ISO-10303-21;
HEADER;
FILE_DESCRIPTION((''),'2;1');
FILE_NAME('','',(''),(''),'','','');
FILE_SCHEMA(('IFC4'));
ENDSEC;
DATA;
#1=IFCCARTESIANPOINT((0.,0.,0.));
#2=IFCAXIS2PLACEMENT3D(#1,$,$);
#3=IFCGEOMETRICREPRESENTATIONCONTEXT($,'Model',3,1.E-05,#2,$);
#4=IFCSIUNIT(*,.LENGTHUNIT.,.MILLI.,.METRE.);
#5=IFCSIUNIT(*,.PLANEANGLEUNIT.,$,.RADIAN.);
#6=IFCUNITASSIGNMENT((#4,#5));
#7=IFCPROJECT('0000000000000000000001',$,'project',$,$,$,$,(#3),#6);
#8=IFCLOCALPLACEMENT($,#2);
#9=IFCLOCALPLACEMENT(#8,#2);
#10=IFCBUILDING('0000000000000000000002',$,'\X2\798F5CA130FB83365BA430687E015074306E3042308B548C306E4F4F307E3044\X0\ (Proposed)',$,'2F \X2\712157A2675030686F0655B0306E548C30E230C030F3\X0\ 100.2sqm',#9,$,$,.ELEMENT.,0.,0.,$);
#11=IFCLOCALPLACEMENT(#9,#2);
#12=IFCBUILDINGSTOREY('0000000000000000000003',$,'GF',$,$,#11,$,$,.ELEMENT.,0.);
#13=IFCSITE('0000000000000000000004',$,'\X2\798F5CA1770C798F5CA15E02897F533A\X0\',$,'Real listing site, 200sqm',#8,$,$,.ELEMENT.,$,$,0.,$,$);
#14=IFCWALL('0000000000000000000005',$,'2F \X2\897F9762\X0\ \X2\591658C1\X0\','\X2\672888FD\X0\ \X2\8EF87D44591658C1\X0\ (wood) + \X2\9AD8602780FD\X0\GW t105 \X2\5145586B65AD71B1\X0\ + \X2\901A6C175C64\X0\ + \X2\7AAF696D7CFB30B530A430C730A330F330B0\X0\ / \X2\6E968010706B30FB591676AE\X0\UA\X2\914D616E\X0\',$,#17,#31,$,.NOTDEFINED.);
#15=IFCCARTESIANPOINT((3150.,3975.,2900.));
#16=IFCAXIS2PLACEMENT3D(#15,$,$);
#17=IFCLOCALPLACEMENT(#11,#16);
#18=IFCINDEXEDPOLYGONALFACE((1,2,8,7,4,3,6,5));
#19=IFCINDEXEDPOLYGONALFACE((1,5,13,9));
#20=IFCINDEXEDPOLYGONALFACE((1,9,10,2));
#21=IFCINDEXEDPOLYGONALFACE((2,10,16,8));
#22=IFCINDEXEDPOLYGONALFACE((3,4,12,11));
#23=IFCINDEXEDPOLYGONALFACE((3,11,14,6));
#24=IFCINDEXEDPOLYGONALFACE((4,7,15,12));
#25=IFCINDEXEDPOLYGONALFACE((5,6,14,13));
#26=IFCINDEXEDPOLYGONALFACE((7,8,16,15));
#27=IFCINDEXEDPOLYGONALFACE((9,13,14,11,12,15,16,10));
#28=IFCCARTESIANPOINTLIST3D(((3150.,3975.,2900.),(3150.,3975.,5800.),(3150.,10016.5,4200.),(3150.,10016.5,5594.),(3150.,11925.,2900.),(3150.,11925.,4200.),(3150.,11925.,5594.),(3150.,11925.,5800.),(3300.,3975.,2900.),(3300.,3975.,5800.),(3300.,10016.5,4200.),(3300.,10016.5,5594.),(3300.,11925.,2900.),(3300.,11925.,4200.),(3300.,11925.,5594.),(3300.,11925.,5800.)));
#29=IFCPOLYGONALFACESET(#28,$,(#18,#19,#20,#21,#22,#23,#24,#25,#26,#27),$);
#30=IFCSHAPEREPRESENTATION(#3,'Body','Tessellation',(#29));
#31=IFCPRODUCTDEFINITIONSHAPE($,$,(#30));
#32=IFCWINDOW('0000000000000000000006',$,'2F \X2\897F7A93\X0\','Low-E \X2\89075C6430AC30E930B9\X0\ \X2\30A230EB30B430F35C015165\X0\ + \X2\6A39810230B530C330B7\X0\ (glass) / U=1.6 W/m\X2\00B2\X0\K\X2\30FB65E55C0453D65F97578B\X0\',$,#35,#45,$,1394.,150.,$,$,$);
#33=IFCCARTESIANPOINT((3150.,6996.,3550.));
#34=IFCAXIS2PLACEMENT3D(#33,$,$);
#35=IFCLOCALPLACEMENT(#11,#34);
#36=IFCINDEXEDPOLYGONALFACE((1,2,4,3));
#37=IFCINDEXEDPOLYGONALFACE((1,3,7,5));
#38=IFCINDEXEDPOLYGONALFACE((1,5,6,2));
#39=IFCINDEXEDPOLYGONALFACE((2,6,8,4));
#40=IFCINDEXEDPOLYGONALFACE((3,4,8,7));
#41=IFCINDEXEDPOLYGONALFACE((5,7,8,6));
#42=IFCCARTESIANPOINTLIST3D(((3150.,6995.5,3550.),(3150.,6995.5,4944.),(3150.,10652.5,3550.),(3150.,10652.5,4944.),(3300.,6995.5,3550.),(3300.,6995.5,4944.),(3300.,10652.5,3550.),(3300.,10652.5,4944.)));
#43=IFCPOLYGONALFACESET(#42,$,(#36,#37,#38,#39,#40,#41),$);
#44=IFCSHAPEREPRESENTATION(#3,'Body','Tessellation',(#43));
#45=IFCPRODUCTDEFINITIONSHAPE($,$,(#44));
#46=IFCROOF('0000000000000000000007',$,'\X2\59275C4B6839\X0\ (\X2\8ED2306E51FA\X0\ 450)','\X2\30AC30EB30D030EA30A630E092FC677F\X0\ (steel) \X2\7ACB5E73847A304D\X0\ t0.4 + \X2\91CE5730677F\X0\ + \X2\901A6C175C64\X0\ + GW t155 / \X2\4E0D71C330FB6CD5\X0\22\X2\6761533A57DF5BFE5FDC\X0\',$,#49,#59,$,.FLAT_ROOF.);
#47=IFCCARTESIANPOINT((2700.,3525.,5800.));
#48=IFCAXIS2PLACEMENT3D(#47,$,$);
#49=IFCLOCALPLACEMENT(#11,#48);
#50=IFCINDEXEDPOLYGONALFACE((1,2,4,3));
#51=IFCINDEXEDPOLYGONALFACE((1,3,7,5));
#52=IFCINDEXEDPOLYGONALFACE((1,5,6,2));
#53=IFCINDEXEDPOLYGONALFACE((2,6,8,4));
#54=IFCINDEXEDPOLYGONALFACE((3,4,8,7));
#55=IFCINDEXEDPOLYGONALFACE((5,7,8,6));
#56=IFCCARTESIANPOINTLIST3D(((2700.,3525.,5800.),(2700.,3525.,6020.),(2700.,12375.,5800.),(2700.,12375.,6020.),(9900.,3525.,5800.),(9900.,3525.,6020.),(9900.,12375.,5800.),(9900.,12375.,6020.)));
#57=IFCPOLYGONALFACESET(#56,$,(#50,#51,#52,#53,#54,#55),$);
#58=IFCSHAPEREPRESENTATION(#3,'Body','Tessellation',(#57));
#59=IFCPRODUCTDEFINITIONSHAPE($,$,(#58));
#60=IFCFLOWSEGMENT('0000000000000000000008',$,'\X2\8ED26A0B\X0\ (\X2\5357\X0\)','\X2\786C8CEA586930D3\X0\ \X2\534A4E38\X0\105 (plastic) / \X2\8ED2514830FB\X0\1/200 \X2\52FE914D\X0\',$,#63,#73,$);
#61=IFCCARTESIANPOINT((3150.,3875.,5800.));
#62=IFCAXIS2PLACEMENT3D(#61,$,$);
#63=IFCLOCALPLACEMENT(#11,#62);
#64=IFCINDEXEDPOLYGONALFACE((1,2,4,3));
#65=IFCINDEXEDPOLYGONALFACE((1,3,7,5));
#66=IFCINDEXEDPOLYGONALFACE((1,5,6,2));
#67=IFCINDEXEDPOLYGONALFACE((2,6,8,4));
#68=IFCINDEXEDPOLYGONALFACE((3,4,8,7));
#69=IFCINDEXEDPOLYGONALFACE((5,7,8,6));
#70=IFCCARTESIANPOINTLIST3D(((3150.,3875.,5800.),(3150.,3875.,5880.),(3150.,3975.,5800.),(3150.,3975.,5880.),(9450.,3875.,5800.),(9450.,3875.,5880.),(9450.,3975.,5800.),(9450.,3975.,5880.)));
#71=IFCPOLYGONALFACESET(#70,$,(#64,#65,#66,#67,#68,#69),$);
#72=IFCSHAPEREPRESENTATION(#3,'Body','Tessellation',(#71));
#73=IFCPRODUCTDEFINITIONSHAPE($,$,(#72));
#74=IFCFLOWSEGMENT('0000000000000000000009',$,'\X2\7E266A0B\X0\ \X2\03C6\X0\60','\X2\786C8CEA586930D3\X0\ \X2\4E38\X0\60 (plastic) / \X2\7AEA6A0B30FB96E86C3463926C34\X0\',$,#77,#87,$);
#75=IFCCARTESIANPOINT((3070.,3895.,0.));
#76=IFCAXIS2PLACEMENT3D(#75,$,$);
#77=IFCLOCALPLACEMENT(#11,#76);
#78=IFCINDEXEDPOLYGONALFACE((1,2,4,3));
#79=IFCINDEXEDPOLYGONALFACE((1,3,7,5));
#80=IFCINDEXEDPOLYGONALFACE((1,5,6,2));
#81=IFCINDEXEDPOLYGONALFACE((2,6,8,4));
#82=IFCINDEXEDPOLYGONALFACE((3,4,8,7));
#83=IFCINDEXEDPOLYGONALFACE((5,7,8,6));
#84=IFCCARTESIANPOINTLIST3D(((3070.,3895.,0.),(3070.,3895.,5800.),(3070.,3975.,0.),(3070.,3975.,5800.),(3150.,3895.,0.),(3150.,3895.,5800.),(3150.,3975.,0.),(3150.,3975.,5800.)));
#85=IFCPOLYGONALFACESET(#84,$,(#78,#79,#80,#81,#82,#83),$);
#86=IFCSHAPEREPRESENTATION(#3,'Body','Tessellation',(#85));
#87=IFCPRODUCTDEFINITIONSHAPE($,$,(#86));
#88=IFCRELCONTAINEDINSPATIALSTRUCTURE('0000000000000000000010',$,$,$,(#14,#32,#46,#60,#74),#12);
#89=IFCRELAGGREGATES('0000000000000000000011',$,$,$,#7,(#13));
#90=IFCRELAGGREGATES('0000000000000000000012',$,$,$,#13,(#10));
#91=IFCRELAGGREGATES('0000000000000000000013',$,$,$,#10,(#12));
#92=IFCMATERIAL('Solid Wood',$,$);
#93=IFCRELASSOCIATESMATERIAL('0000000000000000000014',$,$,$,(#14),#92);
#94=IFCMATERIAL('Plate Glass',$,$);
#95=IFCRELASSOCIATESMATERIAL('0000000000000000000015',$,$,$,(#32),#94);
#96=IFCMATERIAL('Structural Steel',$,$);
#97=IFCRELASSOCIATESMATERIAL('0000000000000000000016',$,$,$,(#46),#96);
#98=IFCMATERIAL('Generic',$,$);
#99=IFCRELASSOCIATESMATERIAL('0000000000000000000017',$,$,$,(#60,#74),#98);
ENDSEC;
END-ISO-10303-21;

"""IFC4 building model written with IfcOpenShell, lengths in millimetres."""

from ifc_helpers import new_model, si_unit, frame, frame_2d, origin, place, context, project, spatial, rectangle, extrude, material, element, fill, save


model = new_model("IFC4")

# Units and contexts
model_context = context("Model", 3, precision=1e-05, world=origin())
ifc_project = project(units=[si_unit("LENGTHUNIT", "METRE", prefix="MILLI"), si_unit("PLANEANGLEUNIT", "RADIAN")], contexts=[model_context])

# Site, building, storey
site_placement = place(None, origin())
site = spatial("IfcSite", under=ifc_project, at=site_placement, Name="福岡県福岡市西区", ObjectType="Real listing site, 200sqm", CompositionType="ELEMENT", RefElevation=0.0)
building_placement = place(site_placement, origin())
building = spatial("IfcBuilding", under=site, at=building_placement, Name="福岡・茶室と縁側のある和の住まい (Proposed)", ObjectType="2F 無垢材と漆喰の和モダン 100.2sqm", CompositionType="ELEMENT", ElevationOfRefHeight=0.0, ElevationOfTerrain=0.0)
storey_placement = place(building_placement, origin())
storey = spatial("IfcBuildingStorey", under=building, at=storey_placement, Name="GF", CompositionType="ELEMENT", Elevation=0.0)

# Shared definitions
ifc_material_1 = material(Name="Solid Wood")

# Shared definitions
ifc_material_2 = material(Name="Plate Glass")

# Wall, opening, window
wall_1_placement = place(storey_placement, frame((3150.0, 3975.0, 2900.0)))
wall_1 = element("IfcWall", 1, at=wall_1_placement, inside=storey, material=ifc_material_1, Name="2F 西面 外壁", Description="木製 軸組外壁 (wood) + 高性能GW t105 充填断熱 + 通気層 + 窯業系サイディング / 準耐火・外皮UA配慮", PredefinedType="NOTDEFINED", context=model_context, shape_type="SweptSolid", body=[
    extrude(rectangle(XDim=150.0, YDim=7950.0, at=frame_2d((75.0, 3975.0))), frame((3150.0, 3975.0, 2900.0)), (0.0, 0.0, 1.0), 2900.0),
])
opening_1_placement = place(storey_placement, frame((3150.0, 6996.0, 3550.0)))
opening_1 = element("IfcOpeningElement", 2, at=opening_1_placement, cuts=wall_1, PredefinedType="NOTDEFINED", context=model_context, shape_type="SweptSolid", body=[
    extrude(rectangle(XDim=150.0, YDim=3657.0, at=frame_2d((75.0, 1828.0))), frame((3150.0, 6996.0, 3550.0)), (0.0, 0.0, 1.0), 1394.0),
])
window_1_placement = place(storey_placement, frame((3150.0, 6996.0, 3550.0)))
window_1 = element("IfcWindow", 3, at=window_1_placement, inside=storey, material=ifc_material_2, Name="2F 西窓", Description="Low-E 複層ガラス アルゴン封入 + 樹脂サッシ (glass) / U=1.6 W/m²K・日射取得型", OverallHeight=1394.0, OverallWidth=150.0, context=model_context, shape_type="SweptSolid", body=[
    extrude(rectangle(XDim=150.0, YDim=3657.0, at=frame_2d((75.0, 1828.0))), frame((3150.0, 6996.0, 3550.0)), (0.0, 0.0, 1.0), 1394.0),
])
fill(opening_1, window_1)

# Roof
ifc_material_3 = material(Name="Structural Steel")
roof_placement = place(storey_placement, frame((2700.0, 3525.0, 5800.0)))
element("IfcRoof", 4, at=roof_placement, inside=storey, material=ifc_material_3, Name="大屋根 (軒の出 450)", Description="ガルバリウム鋼板 (steel) 立平葺き t0.4 + 野地板 + 通気層 + GW t155 / 不燃・法22条区域対応", PredefinedType="FLAT_ROOF", context=model_context, shape_type="SweptSolid", body=[
    extrude(rectangle(XDim=7200.0, YDim=8850.0, at=frame_2d((3600.0, 4425.0))), frame((2700.0, 3525.0, 5800.0)), (0.0, 0.0, 1.0), 220.0),
])

# Flow segments
ifc_material_4 = material(Name="Generic")
flow_segment_1_placement = place(storey_placement, frame((3150.0, 3875.0, 5800.0)))
element("IfcFlowSegment", 5, at=flow_segment_1_placement, inside=storey, material=ifc_material_4, Name="軒樋 (南)", Description="硬質塩ビ 半丸105 (plastic) / 軒先・1/200 勾配", context=model_context, shape_type="SweptSolid", body=[
    extrude(rectangle(XDim=6300.0, YDim=100.0, at=frame_2d((3150.0, 50.0))), frame((3150.0, 3875.0, 5800.0)), (0.0, 0.0, 1.0), 80.0),
])
flow_segment_2_placement = place(storey_placement, frame((3070.0, 3895.0, 0.0)))
element("IfcFlowSegment", 6, at=flow_segment_2_placement, inside=storey, material=ifc_material_4, Name="縦樋 φ60", Description="硬質塩ビ 丸60 (plastic) / 竪樋・雨水排水", context=model_context, shape_type="SweptSolid", body=[
    extrude(rectangle(XDim=80.0, YDim=80.0, at=frame_2d((40.0, 40.0))), frame((3070.0, 3895.0, 0.0)), (0.0, 0.0, 1.0), 5800.0),
])

save(model, "model.ifc")
